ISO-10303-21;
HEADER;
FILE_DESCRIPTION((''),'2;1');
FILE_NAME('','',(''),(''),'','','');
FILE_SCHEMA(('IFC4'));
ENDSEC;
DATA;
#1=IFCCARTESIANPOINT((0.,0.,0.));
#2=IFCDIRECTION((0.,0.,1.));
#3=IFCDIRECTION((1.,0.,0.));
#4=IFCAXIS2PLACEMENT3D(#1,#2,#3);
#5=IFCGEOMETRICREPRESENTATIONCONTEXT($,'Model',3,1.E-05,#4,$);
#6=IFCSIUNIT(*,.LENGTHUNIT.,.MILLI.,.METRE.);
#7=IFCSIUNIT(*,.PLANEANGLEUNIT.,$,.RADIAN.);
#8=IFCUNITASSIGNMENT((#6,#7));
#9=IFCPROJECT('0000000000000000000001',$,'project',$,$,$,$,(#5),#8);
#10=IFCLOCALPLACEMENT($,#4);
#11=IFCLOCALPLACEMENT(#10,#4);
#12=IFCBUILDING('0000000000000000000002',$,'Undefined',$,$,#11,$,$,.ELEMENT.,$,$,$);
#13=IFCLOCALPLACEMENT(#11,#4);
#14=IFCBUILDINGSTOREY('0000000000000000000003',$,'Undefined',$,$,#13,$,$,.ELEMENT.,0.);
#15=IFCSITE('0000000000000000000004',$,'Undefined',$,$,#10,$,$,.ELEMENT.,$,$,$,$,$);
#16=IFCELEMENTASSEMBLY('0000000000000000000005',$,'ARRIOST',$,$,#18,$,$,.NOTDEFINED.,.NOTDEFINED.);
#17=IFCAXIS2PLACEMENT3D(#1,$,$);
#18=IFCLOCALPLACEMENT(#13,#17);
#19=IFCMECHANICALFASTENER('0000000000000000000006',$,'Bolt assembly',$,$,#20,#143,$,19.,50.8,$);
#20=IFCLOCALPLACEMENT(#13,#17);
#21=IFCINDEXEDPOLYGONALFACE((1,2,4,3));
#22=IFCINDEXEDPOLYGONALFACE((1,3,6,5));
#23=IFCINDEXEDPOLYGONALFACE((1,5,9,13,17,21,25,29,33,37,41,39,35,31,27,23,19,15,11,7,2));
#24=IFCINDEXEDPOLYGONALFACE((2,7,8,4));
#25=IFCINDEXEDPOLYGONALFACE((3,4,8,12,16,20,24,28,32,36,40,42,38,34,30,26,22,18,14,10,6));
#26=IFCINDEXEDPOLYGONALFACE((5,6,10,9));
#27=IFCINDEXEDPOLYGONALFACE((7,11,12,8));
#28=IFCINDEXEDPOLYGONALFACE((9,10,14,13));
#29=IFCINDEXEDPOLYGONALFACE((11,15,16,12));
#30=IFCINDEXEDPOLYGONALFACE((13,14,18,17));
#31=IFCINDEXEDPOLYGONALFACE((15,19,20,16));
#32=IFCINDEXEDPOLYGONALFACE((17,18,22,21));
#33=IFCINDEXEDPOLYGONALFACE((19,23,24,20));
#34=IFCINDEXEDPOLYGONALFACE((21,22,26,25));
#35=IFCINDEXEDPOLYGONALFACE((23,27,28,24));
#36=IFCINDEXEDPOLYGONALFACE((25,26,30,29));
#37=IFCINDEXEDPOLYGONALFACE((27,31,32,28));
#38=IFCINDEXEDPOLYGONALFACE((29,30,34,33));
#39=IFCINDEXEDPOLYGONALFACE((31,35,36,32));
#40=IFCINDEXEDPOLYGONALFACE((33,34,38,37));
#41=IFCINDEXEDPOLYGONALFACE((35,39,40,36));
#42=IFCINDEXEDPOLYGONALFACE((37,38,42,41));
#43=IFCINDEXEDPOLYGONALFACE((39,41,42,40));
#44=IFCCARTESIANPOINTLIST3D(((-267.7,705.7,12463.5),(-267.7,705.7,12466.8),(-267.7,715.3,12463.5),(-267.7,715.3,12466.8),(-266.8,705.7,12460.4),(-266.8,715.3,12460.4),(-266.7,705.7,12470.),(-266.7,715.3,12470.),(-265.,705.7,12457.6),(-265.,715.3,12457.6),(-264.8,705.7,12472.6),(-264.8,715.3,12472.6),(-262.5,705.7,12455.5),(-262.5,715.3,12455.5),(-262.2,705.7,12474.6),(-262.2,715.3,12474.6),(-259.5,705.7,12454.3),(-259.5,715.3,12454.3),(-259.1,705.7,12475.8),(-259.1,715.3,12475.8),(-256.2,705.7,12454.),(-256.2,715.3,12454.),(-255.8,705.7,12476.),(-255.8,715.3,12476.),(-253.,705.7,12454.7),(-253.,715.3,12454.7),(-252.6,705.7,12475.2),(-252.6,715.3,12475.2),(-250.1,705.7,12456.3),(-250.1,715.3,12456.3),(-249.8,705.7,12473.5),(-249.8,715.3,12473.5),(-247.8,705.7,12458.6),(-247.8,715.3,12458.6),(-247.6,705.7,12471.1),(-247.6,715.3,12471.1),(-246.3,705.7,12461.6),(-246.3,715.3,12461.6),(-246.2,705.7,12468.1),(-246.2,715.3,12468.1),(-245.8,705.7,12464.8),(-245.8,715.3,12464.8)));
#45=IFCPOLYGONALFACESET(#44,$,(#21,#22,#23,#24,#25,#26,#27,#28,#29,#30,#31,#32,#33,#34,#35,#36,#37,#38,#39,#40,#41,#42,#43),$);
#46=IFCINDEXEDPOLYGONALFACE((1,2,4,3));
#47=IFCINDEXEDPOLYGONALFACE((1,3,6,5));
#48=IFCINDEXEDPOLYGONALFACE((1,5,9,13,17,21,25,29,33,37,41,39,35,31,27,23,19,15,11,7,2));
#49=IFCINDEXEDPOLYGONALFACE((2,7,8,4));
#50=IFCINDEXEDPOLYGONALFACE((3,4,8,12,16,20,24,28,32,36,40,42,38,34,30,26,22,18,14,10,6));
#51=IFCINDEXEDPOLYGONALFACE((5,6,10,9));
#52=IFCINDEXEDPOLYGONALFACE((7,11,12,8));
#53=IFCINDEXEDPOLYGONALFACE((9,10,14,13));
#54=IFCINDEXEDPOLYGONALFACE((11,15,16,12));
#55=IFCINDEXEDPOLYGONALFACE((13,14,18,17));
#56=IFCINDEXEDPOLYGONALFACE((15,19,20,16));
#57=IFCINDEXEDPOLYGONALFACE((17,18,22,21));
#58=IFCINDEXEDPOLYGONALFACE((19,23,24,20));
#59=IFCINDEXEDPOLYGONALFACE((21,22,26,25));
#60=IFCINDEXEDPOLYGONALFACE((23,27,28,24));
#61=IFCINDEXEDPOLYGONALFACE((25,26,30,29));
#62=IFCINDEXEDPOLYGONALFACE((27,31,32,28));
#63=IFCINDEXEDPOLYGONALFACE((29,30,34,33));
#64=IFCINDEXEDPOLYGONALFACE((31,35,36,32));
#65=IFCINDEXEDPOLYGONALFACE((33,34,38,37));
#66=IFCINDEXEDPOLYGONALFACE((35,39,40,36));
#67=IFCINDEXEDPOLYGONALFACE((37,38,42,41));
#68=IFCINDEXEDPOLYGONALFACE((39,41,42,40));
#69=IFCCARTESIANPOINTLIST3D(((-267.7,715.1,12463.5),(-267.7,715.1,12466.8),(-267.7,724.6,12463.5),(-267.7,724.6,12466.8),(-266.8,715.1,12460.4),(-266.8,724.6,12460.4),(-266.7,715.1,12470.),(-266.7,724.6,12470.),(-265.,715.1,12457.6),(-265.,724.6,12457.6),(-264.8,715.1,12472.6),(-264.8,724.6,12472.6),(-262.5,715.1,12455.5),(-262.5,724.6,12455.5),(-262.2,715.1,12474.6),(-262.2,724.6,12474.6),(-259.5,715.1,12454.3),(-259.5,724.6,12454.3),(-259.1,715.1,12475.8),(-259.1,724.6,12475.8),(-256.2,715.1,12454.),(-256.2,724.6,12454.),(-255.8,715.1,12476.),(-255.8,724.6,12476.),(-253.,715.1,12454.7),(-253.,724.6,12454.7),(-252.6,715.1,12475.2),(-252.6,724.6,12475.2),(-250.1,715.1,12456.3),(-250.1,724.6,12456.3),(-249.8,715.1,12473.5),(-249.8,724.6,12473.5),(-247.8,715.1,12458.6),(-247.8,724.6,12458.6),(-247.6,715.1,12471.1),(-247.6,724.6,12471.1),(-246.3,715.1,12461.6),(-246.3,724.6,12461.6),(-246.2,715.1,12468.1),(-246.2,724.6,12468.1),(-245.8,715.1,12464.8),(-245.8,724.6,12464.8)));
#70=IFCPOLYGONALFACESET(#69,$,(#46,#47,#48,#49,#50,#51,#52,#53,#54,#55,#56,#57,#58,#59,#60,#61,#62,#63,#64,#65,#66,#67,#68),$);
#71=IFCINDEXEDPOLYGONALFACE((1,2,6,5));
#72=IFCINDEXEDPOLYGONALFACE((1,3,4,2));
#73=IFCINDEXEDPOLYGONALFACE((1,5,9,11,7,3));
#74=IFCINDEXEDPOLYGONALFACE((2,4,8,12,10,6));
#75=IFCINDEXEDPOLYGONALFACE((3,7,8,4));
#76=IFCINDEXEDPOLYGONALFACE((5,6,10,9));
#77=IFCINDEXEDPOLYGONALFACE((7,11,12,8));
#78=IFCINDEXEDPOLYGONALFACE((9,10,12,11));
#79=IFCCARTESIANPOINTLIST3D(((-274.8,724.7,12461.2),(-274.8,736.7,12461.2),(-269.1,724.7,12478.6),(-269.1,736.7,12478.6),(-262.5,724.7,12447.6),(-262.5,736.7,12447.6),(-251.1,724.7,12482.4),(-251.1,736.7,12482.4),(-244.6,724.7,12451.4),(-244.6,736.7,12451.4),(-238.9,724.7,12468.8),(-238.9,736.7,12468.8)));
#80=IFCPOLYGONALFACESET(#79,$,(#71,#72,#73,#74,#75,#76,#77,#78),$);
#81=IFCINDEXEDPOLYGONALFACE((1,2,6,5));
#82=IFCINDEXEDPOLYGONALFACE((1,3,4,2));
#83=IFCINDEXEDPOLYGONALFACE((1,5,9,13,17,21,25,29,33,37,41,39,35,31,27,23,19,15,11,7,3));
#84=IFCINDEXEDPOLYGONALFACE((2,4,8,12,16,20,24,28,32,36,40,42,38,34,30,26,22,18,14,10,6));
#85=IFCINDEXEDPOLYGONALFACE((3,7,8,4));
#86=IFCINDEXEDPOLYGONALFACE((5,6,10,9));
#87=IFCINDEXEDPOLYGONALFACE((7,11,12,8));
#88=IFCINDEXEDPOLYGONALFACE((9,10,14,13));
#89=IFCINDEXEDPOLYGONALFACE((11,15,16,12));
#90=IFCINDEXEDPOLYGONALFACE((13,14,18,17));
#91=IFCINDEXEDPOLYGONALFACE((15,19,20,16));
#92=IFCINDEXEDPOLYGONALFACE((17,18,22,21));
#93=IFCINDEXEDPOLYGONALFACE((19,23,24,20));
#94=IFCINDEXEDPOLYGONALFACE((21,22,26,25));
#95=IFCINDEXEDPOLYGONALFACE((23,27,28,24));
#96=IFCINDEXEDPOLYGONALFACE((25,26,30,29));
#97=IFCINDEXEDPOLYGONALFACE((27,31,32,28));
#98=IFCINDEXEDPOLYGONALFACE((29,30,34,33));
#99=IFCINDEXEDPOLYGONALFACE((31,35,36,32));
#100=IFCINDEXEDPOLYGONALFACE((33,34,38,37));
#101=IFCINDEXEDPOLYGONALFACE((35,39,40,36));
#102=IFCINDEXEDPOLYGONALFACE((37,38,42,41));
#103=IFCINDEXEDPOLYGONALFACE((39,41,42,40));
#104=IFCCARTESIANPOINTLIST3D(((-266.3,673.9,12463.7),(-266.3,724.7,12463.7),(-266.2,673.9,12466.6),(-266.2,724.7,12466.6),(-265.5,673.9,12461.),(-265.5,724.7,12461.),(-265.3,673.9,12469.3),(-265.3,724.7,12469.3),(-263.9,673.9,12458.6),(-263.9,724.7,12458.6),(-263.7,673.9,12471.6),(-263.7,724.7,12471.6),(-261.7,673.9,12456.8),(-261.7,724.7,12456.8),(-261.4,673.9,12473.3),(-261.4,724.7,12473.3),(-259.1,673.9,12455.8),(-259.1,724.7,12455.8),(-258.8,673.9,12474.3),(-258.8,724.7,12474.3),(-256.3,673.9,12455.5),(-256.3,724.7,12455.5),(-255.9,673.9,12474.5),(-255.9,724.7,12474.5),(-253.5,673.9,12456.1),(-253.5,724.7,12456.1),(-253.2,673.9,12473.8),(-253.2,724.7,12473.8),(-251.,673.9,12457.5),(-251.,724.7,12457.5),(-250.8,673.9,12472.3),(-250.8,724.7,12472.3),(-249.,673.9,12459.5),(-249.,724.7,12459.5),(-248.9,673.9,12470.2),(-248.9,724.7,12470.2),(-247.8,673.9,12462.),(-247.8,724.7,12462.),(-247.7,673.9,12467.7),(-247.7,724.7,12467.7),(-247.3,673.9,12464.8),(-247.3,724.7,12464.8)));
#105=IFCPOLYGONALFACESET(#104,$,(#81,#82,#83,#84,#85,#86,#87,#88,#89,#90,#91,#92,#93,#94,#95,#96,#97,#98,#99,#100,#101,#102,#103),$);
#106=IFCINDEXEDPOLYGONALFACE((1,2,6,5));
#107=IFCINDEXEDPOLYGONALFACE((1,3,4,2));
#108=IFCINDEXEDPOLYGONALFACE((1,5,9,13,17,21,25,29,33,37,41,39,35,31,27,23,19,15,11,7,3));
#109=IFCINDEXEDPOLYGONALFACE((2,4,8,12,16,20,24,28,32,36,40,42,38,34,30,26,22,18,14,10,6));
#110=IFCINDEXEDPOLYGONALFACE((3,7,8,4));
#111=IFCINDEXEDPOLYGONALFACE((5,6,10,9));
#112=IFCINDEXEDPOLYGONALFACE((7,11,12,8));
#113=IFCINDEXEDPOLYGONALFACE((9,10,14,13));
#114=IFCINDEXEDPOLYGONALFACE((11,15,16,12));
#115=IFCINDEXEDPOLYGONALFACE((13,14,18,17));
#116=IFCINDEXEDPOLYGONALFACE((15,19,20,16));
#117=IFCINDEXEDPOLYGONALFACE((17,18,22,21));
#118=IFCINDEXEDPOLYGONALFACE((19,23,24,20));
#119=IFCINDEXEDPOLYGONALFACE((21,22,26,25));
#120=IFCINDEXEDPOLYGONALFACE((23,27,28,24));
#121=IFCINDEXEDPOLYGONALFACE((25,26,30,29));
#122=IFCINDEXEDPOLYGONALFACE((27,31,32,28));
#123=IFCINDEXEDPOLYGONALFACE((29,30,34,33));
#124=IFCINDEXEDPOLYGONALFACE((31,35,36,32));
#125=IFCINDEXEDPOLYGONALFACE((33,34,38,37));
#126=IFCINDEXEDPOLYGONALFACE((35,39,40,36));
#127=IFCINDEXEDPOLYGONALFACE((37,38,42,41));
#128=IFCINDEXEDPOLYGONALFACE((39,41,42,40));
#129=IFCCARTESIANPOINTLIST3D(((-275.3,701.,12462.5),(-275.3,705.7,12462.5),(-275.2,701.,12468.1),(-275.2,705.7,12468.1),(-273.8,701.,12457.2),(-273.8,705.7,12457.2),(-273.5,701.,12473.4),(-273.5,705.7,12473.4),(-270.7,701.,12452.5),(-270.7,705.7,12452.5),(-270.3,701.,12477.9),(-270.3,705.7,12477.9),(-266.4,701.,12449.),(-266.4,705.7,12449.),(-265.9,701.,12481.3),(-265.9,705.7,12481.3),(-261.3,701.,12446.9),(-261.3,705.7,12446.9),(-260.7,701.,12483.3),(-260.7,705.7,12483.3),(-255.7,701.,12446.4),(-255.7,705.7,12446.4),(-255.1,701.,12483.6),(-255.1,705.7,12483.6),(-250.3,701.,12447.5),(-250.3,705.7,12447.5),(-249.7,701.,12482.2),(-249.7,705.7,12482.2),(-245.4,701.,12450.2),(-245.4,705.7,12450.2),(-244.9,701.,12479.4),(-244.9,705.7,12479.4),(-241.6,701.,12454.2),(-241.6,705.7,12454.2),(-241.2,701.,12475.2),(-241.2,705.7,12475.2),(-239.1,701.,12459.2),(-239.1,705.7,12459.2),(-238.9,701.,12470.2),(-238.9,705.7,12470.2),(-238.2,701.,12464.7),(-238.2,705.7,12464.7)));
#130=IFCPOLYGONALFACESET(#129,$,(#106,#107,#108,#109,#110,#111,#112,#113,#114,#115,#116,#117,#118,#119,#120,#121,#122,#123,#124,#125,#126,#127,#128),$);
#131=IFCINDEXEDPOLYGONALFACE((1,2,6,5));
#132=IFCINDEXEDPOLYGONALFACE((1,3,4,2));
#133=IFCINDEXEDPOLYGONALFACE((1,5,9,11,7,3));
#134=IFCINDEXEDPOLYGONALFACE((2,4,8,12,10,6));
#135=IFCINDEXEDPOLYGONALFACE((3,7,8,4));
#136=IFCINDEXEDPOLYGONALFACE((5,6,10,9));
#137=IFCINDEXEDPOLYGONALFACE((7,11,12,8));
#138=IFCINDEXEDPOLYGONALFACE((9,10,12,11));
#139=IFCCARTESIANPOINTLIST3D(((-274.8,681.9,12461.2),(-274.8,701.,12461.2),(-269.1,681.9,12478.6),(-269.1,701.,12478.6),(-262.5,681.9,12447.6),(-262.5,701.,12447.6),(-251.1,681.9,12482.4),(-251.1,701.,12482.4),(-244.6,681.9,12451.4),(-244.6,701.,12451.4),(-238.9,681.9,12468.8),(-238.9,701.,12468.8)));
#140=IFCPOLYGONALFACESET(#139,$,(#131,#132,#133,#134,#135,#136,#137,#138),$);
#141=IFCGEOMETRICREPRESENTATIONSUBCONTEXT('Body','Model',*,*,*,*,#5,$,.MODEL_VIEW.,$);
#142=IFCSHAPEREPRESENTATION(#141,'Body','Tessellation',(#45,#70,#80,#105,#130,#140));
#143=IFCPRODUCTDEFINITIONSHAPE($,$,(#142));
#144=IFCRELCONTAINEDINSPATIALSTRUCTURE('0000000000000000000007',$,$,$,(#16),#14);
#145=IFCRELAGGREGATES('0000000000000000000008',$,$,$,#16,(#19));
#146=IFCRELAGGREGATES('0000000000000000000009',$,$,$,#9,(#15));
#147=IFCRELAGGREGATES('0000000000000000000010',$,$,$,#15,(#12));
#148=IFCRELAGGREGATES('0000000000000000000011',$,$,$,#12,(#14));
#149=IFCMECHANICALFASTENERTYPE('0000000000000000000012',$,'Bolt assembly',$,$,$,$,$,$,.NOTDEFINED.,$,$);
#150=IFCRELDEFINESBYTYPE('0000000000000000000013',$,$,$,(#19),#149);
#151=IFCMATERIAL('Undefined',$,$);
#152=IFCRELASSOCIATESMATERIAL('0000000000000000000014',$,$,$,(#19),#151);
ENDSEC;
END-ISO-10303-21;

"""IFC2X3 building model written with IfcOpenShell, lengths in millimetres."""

from ifc_helpers import new_model, si_unit, frame, origin_with_axes, origin_2d_with_axis, place, context, subcontext, project, spatial, polyline, circle, outline, extrude, source, transform, mapped, material, type_object, element, aggregate, save


model = new_model("IFC2X3")

# Units and contexts
model_context = context("Model", 3, precision=1e-05, world=origin_with_axes())
body_context = subcontext(model_context, "Body", "Model", "MODEL_VIEW")
ifc_project = project(units=[si_unit("LENGTHUNIT", "METRE", prefix="MILLI"), si_unit("PLANEANGLEUNIT", "RADIAN")], contexts=[model_context])

# Site, building, storey
site_placement = place(None, origin_with_axes())
site = spatial("IfcSite", under=ifc_project, at=site_placement, Name="Undefined", CompositionType="ELEMENT")
building_placement = place(site_placement, origin_with_axes())
building = spatial("IfcBuilding", under=site, at=building_placement, Name="Undefined", CompositionType="ELEMENT")
storey_placement = place(building_placement, origin_with_axes())
storey = spatial("IfcBuildingStorey", under=building, at=storey_placement, Name="Undefined", CompositionType="ELEMENT", Elevation=0.0)

# Element assembly
assembly_1_placement = place(storey_placement, origin_with_axes())
assembly_1 = element("IfcElementAssembly", 1, at=assembly_1_placement, inside=storey, Name="ARRIOST", AssemblyPlace="NOTDEFINED", PredefinedType="NOTDEFINED")

# Shared definitions
ifc_material_1 = material(Name="Undefined")
mechanical_fastener_type = type_object("IfcMechanicalFastenerType", Name="Bolt assembly")

# Mechanical fastener
shared_shape_1 = source(origin_with_axes(), body_context, "Body", "SweptSolid", [
    extrude(circle(Radius=11.0, at=origin_2d_with_axis()), frame((0.0, 4.6, 0.0), z_axis=(0.0, 1.0, 0.0), x_axis=(1.0, 0.0, 0.0)), (0.0, 0.0, 1.0), 9.6),
    extrude(circle(Radius=11.0, at=origin_2d_with_axis()), frame((0.0, -4.6, 0.0), z_axis=(0.0, 1.0, 0.0), x_axis=(1.0, 0.0, 0.0)), (0.0, 0.0, 1.0), 9.5),
    extrude(outline(polyline([(15.9, -9.2), (15.9, 9.2), (0.0, 18.3), (-15.9, 9.2), (-15.9, -9.2), (0.0, -18.3), (15.9, -9.2)])), frame((0.0, -16.7, 0.0), z_axis=(0.0, 1.0, 0.0), x_axis=(1.0, 0.0, 0.0)), (0.0, 0.0, 1.0), 11.9),
    extrude(circle(Radius=9.5, at=origin_2d_with_axis()), frame((0.0, -4.7, 0.0), z_axis=(0.0, 1.0, 0.0), x_axis=(1.0, 0.0, 0.0)), (0.0, 0.0, 1.0), 50.8),
    extrude(circle(Radius=18.7, at=origin_2d_with_axis()), frame((0.0, 14.2, 0.0), z_axis=(0.0, 1.0, 0.0), x_axis=(1.0, 0.0, 0.0)), (0.0, 0.0, 1.0), 4.8),
    extrude(outline(polyline([(15.9, -9.2), (15.9, 9.2), (0.0, 18.3), (-15.9, 9.2), (-15.9, -9.2), (0.0, -18.3), (15.9, -9.2)])), frame((0.0, 19.0, 0.0), z_axis=(0.0, 1.0, 0.0), x_axis=(1.0, 0.0, 0.0)), (0.0, 0.0, 1.0), 19.1),
])
mechanical_fastener_1_placement = place(assembly_1_placement, frame((-256.8, 720.0, 12465.0), z_axis=(-0.310857, 0.0, -0.950457), x_axis=(0.950457, 0.0, -0.310857)))
mechanical_fastener_1 = element("IfcMechanicalFastener", 2, at=mechanical_fastener_1_placement, type_object=mechanical_fastener_type, material=ifc_material_1, Name="Bolt assembly", NominalDiameter=19.0, NominalLength=50.8, context=body_context, shape_type="MappedRepresentation", body=[
    mapped(shared_shape_1, transform((0.0, 0.0, 0.0))),
])
aggregate(assembly_1, [mechanical_fastener_1])

save(model, "model.ifc")
